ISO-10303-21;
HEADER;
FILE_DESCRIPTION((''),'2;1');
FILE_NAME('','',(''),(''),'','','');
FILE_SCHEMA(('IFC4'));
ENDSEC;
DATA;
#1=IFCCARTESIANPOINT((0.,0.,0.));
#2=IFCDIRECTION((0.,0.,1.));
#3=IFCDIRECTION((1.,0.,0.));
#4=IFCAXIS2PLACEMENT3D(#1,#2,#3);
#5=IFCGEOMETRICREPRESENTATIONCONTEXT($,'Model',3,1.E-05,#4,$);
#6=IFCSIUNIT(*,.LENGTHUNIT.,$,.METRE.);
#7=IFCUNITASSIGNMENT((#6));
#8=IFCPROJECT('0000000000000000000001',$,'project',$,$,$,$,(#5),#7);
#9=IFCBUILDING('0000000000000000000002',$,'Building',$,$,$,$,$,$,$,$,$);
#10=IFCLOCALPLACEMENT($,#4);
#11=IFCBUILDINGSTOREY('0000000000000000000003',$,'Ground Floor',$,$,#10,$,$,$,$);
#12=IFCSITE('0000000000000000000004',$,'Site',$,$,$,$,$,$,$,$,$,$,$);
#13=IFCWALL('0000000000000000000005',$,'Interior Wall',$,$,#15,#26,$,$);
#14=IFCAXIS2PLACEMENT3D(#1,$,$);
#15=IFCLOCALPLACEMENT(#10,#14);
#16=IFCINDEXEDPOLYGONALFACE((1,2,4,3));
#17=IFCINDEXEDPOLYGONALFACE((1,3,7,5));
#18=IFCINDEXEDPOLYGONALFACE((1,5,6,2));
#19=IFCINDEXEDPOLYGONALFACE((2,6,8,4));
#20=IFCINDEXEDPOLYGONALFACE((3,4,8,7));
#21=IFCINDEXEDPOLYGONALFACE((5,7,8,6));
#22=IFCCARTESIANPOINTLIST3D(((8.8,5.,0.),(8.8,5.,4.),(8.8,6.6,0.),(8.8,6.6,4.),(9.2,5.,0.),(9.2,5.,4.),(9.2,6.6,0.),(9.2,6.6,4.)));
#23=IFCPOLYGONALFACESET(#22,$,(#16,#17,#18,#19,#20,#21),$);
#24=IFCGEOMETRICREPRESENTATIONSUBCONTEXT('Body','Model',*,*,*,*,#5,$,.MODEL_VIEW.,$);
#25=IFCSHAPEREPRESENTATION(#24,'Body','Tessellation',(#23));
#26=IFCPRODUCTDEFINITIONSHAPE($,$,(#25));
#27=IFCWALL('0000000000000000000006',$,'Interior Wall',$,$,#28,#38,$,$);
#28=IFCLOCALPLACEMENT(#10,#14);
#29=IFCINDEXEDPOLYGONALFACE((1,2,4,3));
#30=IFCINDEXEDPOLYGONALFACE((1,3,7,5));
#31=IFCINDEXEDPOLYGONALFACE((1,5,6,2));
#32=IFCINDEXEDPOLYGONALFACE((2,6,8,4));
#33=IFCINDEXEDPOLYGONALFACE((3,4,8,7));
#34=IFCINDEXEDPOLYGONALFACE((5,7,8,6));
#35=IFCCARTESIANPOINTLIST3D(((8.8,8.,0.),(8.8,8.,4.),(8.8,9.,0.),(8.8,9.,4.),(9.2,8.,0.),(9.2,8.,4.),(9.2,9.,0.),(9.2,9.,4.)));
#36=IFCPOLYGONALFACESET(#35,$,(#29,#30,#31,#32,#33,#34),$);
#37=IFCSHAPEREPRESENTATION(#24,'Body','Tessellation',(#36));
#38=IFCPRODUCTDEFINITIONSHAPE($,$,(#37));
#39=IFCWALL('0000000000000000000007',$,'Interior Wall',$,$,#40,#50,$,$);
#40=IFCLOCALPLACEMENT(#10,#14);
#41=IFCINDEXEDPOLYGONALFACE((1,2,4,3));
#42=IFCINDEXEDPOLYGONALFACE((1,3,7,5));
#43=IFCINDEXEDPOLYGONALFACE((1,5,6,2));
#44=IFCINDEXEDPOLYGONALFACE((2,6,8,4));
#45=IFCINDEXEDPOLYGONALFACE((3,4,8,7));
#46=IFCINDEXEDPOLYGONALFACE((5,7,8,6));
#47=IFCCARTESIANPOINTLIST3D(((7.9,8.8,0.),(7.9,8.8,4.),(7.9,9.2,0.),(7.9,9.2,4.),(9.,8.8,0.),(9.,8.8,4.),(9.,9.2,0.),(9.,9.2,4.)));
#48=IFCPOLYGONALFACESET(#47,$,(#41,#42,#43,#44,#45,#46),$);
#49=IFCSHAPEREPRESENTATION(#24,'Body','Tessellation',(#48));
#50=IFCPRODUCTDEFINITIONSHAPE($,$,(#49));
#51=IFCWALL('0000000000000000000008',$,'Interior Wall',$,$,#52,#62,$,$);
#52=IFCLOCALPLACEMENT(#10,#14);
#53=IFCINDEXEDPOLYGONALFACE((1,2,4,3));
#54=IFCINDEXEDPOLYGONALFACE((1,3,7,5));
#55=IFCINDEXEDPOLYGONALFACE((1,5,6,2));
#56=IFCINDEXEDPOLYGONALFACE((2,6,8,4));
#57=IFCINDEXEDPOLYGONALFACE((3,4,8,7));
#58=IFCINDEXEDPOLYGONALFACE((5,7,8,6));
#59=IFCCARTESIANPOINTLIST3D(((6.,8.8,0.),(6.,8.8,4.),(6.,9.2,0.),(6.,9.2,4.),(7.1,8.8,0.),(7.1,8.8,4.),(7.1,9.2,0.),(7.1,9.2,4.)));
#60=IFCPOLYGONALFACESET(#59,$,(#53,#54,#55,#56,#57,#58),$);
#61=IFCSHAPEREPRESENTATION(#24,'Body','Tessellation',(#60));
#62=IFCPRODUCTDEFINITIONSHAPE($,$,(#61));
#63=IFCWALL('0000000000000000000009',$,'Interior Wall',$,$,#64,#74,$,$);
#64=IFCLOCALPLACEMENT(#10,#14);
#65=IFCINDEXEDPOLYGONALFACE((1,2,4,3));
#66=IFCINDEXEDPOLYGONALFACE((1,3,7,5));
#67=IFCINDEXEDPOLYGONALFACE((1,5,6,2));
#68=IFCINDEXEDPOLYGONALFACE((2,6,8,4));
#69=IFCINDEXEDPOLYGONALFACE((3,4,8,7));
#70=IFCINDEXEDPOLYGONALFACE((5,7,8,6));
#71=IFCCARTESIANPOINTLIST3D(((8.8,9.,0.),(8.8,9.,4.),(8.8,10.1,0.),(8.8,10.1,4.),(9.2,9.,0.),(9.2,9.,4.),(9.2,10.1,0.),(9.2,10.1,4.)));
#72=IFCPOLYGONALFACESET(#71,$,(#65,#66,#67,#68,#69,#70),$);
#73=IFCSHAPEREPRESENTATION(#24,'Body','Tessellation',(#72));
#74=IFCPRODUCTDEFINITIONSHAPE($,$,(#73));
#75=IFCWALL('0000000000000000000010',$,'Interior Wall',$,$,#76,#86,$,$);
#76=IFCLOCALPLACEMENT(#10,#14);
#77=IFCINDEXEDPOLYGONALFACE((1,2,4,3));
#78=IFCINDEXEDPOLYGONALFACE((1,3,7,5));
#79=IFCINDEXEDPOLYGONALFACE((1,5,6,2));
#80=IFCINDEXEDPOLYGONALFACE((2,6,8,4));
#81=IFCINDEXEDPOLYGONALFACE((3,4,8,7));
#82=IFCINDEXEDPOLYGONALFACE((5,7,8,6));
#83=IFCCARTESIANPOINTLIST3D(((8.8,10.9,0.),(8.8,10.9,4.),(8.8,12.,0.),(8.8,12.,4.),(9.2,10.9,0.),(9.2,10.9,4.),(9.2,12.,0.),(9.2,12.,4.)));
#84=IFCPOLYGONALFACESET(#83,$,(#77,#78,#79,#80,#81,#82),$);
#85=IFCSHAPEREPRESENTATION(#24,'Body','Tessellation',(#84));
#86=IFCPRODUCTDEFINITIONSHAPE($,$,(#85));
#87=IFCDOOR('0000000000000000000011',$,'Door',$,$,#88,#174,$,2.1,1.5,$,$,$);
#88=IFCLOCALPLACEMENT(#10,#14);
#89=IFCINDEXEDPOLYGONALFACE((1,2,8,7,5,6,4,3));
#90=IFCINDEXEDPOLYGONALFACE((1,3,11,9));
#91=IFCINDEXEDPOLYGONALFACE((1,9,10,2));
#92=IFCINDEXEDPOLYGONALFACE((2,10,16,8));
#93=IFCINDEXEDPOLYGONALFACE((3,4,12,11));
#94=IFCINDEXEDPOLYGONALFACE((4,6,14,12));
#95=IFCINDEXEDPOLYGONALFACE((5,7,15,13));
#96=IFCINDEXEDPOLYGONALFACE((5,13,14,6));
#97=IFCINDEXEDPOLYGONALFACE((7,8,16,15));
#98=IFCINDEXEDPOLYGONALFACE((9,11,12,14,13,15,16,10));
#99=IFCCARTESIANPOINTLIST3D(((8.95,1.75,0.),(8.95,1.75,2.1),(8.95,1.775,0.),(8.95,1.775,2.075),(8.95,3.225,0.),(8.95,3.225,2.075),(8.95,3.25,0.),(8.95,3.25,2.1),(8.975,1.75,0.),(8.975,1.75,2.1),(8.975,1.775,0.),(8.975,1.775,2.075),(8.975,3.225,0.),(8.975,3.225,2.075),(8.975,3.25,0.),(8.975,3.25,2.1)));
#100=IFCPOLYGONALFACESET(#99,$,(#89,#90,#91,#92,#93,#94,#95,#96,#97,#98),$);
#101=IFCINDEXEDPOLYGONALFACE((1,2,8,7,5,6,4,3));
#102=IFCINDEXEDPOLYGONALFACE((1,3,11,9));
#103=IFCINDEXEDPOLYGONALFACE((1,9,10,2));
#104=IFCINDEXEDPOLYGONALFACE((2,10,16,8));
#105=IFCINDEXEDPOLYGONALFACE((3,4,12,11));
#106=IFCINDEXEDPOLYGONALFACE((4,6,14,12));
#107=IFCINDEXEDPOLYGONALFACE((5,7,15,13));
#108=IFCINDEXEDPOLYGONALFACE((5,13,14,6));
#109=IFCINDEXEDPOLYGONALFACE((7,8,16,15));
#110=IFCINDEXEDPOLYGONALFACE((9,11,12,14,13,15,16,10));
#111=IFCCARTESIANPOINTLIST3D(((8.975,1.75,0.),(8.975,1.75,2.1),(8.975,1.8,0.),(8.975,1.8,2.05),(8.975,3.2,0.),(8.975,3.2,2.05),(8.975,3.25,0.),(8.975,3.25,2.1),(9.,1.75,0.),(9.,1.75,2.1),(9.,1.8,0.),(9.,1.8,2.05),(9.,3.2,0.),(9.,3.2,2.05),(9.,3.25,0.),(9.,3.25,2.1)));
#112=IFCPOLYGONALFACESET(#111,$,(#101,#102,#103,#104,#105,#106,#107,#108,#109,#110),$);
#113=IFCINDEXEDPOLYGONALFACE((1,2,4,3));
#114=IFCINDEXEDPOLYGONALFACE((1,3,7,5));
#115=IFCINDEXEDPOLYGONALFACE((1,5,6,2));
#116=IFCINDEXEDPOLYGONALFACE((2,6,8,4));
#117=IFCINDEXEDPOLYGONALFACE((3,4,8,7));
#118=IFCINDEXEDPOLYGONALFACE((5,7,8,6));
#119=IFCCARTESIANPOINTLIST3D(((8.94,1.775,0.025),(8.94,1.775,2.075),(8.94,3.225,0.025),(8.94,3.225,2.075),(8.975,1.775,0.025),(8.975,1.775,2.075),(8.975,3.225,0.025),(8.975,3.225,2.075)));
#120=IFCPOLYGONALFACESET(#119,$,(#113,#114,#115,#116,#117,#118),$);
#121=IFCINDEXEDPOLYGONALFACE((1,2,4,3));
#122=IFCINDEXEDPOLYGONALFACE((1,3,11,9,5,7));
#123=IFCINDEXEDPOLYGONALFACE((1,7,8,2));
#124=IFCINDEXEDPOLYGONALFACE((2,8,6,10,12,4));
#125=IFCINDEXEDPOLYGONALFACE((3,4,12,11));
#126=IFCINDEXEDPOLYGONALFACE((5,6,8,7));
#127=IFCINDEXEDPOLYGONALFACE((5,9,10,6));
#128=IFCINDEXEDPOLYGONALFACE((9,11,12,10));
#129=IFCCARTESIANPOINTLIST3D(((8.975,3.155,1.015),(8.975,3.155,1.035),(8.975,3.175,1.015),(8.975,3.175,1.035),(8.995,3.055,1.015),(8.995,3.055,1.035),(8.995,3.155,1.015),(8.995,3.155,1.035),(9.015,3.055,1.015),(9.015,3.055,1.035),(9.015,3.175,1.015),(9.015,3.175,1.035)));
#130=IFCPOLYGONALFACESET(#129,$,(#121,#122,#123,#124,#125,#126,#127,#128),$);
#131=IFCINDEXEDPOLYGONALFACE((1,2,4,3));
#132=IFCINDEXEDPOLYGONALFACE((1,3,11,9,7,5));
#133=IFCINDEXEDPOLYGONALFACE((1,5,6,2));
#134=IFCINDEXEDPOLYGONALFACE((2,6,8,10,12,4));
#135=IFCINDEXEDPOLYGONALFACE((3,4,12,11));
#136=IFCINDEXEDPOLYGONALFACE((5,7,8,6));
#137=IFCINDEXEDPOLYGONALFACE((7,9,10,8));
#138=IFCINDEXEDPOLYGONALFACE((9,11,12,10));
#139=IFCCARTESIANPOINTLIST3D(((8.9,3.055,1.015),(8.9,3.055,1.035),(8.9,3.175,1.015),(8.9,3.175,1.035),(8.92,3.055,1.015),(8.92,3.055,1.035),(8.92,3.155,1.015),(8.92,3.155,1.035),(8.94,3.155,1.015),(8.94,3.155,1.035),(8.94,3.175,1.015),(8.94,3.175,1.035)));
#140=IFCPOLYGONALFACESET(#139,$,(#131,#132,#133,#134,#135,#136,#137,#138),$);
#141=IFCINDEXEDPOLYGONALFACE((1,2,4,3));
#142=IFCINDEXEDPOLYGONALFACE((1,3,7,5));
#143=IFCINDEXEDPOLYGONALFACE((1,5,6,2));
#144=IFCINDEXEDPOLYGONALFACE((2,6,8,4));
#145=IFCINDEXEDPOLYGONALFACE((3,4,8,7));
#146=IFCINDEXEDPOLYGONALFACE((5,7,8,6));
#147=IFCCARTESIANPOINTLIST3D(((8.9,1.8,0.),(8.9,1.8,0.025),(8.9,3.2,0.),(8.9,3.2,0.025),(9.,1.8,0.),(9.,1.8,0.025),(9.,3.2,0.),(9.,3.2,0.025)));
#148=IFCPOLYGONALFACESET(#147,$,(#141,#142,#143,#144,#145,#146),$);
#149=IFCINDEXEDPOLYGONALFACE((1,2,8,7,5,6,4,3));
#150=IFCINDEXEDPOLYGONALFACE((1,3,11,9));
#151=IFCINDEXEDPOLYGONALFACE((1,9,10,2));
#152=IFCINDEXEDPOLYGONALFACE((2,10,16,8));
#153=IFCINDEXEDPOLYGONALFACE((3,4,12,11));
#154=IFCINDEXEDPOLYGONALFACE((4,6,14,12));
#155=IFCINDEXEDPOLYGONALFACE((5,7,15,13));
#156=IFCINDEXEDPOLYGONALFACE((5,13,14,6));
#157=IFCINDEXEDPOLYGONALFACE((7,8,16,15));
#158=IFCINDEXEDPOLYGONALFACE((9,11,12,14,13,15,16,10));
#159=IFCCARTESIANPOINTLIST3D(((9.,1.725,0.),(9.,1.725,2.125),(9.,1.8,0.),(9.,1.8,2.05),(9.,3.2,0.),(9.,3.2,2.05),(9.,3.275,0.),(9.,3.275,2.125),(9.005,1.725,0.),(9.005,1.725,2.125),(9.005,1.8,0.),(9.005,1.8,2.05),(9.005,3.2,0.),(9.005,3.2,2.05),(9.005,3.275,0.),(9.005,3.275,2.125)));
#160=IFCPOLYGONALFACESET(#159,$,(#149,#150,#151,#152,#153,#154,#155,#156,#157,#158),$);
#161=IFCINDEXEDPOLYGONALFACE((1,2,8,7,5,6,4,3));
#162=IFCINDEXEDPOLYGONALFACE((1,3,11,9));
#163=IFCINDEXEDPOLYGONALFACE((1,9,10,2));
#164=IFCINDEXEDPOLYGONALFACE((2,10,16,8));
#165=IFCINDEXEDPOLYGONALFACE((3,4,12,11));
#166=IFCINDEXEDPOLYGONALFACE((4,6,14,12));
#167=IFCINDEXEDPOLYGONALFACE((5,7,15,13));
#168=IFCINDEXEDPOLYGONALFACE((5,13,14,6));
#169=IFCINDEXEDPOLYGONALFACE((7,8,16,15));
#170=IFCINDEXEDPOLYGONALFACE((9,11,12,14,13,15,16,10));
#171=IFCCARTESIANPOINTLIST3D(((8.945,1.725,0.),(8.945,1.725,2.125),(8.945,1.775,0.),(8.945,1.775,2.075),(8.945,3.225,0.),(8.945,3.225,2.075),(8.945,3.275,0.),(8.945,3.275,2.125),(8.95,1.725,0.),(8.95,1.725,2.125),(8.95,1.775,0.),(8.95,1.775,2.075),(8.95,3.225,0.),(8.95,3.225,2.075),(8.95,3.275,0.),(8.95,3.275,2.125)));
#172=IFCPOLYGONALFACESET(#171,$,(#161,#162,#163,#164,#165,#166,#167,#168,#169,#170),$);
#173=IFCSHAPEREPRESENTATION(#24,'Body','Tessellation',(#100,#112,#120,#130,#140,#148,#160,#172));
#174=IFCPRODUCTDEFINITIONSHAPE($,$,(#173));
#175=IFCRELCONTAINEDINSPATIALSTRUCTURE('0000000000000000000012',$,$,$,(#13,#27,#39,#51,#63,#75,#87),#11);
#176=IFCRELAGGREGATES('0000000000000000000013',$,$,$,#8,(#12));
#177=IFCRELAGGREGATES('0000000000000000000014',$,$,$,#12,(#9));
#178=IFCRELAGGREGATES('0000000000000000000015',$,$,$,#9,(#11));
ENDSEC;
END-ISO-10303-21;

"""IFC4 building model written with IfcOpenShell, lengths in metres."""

from ifc_helpers import new_model, si_unit, frame, origin_with_axes, place, context, subcontext, project, spatial, line, indexed_curve, outline, extrude, element, save


model = new_model("IFC4")

# Units and contexts
model_context = context("Model", 3, precision=1e-05, world=origin_with_axes())
body_context = subcontext(model_context, "Body", "Model", "MODEL_VIEW")
ifc_project = project(units=[si_unit("LENGTHUNIT", "METRE")], contexts=[model_context])

# Site, building, storey
site = spatial("IfcSite", under=ifc_project, Name="Site")
building = spatial("IfcBuilding", under=site, Name="Building")
storey_placement = place(None, origin_with_axes())
storey = spatial("IfcBuildingStorey", under=building, at=storey_placement, Name="Ground Floor")

# Walls
wall_1_placement = place(storey_placement, frame((9.0, 6.6, 0.0), z_axis=(0.0, 0.0, 1.0), x_axis=(0.0, -1.0, 0.0)))
element("IfcWall", 1, at=wall_1_placement, inside=storey, Name="Interior Wall", context=body_context, shape_type="SweptSolid", body=[
    extrude(outline(indexed_curve([(0.0, 0.0), (0.0, 0.4), (1.6, 0.4), (1.6, 0.0), (0.0, 0.0)], self_intersect=False)), frame((0.0, -0.2, 0.0), z_axis=(0.0, 0.0, 1.0), x_axis=(1.0, 0.0, 0.0)), (0.0, 0.0, 1.0), 4.0),
])
wall_2_placement = place(storey_placement, frame((9.0, 8.0, 0.0), z_axis=(0.0, 0.0, 1.0), x_axis=(0.0, 1.0, 0.0)))
element("IfcWall", 2, at=wall_2_placement, inside=storey, Name="Interior Wall", context=body_context, shape_type="SweptSolid", body=[
    extrude(outline(indexed_curve([(0.0, 0.0), (0.0, 0.4), (1.0, 0.4), (1.0, 0.0), (0.0, 0.0)], self_intersect=False)), frame((0.0, -0.2, 0.0), z_axis=(0.0, 0.0, 1.0), x_axis=(1.0, 0.0, 0.0)), (0.0, 0.0, 1.0), 4.0),
])
for number, where, z_axis, x_axis, name in (
    (3, (9.0, 9.0, 0.0), (0.0, 0.0, 1.0), (-1.0, 0.0, 0.0), "Interior Wall"),
    (4, (7.1, 9.0, 0.0), (0.0, 0.0, 1.0), (-1.0, 0.0, 0.0), "Interior Wall"),
    (5, (9.0, 9.0, 0.0), (0.0, 0.0, 1.0), (0.0, 1.0, 0.0), "Interior Wall"),
    (6, (9.0, 10.9, 0.0), (0.0, 0.0, 1.0), (0.0, 1.0, 0.0), "Interior Wall"),
):
    element("IfcWall", number, at=place(storey_placement, frame(where, z_axis=z_axis, x_axis=x_axis)), inside=storey, Name=name, context=body_context, shape_type="SweptSolid", body=[
        extrude(outline(indexed_curve([(0.0, 0.0), (0.0, 0.4), (1.1, 0.4), (1.1, 0.0), (0.0, 0.0)], self_intersect=False)), frame((0.0, -0.2, 0.0), z_axis=(0.0, 0.0, 1.0), x_axis=(1.0, 0.0, 0.0)), (0.0, 0.0, 1.0), 4.0),
    ])

# Door
door_1_placement = place(storey_placement, frame((9.0, 1.75, 0.0), z_axis=(0.0, 0.0, 1.0), x_axis=(0.0, 1.0, 0.0)))
element("IfcDoor", 7, at=door_1_placement, inside=storey, Name="Door", OverallHeight=2.1, OverallWidth=1.5, context=body_context, shape_type="SweptSolid", body=[
    extrude(outline(indexed_curve([(0.0, 0.0), (0.0, 2.1), (1.5, 2.1), (1.5, 0.0), (1.475, 0.0), (1.475, 2.075), (0.025, 2.075), (0.025, 0.0)], segments=[line(1, 2, 3, 4, 5, 6, 7, 8, 1)])), frame((0.0, 0.025, 0.0), z_axis=(0.0, -1.0, 0.0), x_axis=(1.0, 0.0, 0.0)), (0.0, 0.0, -1.0), 0.025),
    extrude(outline(indexed_curve([(0.0, 0.0), (0.0, 2.1), (1.5, 2.1), (1.5, 0.0), (1.45, 0.0), (1.45, 2.05), (0.05, 2.05), (0.05, 0.0)], segments=[line(1, 2, 3, 4, 5, 6, 7, 8, 1)])), frame((0.0, 0.0, 0.0), z_axis=(0.0, -1.0, 0.0), x_axis=(1.0, 0.0, 0.0)), (0.0, 0.0, -1.0), 0.025),
    extrude(outline(indexed_curve([(0.0, 0.0), (1.45, 0.0), (1.45, 0.035), (0.0, 0.035)], segments=[line(1, 2, 3, 4, 1)])), frame((0.025, 0.025, 0.025), z_axis=(0.0, 0.0, 1.0), x_axis=(1.0, 0.0, 0.0)), (0.0, 0.0, 1.0), 2.05),
    extrude(outline(indexed_curve([(0.0, 0.0), (0.0, -0.04), (-0.12, -0.04), (-0.12, -0.02), (-0.02, -0.02), (-0.02, 0.0)], segments=[line(1, 2, 3, 4, 5, 6, 1)])), frame((1.425, 0.025, 1.015), z_axis=(0.0, 0.0, 1.0), x_axis=(1.0, 0.0, 0.0)), (0.0, 0.0, 1.0), 0.02),
    extrude(outline(indexed_curve([(0.0, 0.0), (0.0, 0.04), (-0.12, 0.04), (-0.12, 0.02), (-0.02, 0.02), (-0.02, 0.0)], segments=[line(1, 2, 3, 4, 5, 6, 1)])), frame((1.425, 0.06, 1.015), z_axis=(0.0, 0.0, 1.0), x_axis=(1.0, 0.0, 0.0)), (0.0, 0.0, 1.0), 0.02),
    extrude(outline(indexed_curve([(0.0, 0.0), (1.4, 0.0), (1.4, 0.1), (0.0, 0.1)], segments=[line(1, 2, 3, 4, 1)])), frame((0.05, 0.0, 0.0), z_axis=(0.0, 0.0, 1.0), x_axis=(1.0, 0.0, 0.0)), (0.0, 0.0, 1.0), 0.025),
    extrude(outline(indexed_curve([(0.0, 0.0), (0.0, 2.125), (1.55, 2.125), (1.55, 0.0), (1.475, 0.0), (1.475, 2.05), (0.075, 2.05), (0.075, 0.0)], segments=[line(1, 2, 3, 4, 5, 6, 7, 8, 1)])), frame((-0.025, -0.005, 0.0), z_axis=(0.0, -1.0, 0.0), x_axis=(1.0, 0.0, 0.0)), (0.0, 0.0, -1.0), 0.005),
    extrude(outline(indexed_curve([(0.0, 0.0), (0.0, 2.125), (1.55, 2.125), (1.55, 0.0), (1.5, 0.0), (1.5, 2.075), (0.05, 2.075), (0.05, 0.0)], segments=[line(1, 2, 3, 4, 5, 6, 7, 8, 1)])), frame((-0.025, 0.05, 0.0), z_axis=(0.0, -1.0, 0.0), x_axis=(1.0, 0.0, 0.0)), (0.0, 0.0, -1.0), 0.005),
])

save(model, "model.ifc")
